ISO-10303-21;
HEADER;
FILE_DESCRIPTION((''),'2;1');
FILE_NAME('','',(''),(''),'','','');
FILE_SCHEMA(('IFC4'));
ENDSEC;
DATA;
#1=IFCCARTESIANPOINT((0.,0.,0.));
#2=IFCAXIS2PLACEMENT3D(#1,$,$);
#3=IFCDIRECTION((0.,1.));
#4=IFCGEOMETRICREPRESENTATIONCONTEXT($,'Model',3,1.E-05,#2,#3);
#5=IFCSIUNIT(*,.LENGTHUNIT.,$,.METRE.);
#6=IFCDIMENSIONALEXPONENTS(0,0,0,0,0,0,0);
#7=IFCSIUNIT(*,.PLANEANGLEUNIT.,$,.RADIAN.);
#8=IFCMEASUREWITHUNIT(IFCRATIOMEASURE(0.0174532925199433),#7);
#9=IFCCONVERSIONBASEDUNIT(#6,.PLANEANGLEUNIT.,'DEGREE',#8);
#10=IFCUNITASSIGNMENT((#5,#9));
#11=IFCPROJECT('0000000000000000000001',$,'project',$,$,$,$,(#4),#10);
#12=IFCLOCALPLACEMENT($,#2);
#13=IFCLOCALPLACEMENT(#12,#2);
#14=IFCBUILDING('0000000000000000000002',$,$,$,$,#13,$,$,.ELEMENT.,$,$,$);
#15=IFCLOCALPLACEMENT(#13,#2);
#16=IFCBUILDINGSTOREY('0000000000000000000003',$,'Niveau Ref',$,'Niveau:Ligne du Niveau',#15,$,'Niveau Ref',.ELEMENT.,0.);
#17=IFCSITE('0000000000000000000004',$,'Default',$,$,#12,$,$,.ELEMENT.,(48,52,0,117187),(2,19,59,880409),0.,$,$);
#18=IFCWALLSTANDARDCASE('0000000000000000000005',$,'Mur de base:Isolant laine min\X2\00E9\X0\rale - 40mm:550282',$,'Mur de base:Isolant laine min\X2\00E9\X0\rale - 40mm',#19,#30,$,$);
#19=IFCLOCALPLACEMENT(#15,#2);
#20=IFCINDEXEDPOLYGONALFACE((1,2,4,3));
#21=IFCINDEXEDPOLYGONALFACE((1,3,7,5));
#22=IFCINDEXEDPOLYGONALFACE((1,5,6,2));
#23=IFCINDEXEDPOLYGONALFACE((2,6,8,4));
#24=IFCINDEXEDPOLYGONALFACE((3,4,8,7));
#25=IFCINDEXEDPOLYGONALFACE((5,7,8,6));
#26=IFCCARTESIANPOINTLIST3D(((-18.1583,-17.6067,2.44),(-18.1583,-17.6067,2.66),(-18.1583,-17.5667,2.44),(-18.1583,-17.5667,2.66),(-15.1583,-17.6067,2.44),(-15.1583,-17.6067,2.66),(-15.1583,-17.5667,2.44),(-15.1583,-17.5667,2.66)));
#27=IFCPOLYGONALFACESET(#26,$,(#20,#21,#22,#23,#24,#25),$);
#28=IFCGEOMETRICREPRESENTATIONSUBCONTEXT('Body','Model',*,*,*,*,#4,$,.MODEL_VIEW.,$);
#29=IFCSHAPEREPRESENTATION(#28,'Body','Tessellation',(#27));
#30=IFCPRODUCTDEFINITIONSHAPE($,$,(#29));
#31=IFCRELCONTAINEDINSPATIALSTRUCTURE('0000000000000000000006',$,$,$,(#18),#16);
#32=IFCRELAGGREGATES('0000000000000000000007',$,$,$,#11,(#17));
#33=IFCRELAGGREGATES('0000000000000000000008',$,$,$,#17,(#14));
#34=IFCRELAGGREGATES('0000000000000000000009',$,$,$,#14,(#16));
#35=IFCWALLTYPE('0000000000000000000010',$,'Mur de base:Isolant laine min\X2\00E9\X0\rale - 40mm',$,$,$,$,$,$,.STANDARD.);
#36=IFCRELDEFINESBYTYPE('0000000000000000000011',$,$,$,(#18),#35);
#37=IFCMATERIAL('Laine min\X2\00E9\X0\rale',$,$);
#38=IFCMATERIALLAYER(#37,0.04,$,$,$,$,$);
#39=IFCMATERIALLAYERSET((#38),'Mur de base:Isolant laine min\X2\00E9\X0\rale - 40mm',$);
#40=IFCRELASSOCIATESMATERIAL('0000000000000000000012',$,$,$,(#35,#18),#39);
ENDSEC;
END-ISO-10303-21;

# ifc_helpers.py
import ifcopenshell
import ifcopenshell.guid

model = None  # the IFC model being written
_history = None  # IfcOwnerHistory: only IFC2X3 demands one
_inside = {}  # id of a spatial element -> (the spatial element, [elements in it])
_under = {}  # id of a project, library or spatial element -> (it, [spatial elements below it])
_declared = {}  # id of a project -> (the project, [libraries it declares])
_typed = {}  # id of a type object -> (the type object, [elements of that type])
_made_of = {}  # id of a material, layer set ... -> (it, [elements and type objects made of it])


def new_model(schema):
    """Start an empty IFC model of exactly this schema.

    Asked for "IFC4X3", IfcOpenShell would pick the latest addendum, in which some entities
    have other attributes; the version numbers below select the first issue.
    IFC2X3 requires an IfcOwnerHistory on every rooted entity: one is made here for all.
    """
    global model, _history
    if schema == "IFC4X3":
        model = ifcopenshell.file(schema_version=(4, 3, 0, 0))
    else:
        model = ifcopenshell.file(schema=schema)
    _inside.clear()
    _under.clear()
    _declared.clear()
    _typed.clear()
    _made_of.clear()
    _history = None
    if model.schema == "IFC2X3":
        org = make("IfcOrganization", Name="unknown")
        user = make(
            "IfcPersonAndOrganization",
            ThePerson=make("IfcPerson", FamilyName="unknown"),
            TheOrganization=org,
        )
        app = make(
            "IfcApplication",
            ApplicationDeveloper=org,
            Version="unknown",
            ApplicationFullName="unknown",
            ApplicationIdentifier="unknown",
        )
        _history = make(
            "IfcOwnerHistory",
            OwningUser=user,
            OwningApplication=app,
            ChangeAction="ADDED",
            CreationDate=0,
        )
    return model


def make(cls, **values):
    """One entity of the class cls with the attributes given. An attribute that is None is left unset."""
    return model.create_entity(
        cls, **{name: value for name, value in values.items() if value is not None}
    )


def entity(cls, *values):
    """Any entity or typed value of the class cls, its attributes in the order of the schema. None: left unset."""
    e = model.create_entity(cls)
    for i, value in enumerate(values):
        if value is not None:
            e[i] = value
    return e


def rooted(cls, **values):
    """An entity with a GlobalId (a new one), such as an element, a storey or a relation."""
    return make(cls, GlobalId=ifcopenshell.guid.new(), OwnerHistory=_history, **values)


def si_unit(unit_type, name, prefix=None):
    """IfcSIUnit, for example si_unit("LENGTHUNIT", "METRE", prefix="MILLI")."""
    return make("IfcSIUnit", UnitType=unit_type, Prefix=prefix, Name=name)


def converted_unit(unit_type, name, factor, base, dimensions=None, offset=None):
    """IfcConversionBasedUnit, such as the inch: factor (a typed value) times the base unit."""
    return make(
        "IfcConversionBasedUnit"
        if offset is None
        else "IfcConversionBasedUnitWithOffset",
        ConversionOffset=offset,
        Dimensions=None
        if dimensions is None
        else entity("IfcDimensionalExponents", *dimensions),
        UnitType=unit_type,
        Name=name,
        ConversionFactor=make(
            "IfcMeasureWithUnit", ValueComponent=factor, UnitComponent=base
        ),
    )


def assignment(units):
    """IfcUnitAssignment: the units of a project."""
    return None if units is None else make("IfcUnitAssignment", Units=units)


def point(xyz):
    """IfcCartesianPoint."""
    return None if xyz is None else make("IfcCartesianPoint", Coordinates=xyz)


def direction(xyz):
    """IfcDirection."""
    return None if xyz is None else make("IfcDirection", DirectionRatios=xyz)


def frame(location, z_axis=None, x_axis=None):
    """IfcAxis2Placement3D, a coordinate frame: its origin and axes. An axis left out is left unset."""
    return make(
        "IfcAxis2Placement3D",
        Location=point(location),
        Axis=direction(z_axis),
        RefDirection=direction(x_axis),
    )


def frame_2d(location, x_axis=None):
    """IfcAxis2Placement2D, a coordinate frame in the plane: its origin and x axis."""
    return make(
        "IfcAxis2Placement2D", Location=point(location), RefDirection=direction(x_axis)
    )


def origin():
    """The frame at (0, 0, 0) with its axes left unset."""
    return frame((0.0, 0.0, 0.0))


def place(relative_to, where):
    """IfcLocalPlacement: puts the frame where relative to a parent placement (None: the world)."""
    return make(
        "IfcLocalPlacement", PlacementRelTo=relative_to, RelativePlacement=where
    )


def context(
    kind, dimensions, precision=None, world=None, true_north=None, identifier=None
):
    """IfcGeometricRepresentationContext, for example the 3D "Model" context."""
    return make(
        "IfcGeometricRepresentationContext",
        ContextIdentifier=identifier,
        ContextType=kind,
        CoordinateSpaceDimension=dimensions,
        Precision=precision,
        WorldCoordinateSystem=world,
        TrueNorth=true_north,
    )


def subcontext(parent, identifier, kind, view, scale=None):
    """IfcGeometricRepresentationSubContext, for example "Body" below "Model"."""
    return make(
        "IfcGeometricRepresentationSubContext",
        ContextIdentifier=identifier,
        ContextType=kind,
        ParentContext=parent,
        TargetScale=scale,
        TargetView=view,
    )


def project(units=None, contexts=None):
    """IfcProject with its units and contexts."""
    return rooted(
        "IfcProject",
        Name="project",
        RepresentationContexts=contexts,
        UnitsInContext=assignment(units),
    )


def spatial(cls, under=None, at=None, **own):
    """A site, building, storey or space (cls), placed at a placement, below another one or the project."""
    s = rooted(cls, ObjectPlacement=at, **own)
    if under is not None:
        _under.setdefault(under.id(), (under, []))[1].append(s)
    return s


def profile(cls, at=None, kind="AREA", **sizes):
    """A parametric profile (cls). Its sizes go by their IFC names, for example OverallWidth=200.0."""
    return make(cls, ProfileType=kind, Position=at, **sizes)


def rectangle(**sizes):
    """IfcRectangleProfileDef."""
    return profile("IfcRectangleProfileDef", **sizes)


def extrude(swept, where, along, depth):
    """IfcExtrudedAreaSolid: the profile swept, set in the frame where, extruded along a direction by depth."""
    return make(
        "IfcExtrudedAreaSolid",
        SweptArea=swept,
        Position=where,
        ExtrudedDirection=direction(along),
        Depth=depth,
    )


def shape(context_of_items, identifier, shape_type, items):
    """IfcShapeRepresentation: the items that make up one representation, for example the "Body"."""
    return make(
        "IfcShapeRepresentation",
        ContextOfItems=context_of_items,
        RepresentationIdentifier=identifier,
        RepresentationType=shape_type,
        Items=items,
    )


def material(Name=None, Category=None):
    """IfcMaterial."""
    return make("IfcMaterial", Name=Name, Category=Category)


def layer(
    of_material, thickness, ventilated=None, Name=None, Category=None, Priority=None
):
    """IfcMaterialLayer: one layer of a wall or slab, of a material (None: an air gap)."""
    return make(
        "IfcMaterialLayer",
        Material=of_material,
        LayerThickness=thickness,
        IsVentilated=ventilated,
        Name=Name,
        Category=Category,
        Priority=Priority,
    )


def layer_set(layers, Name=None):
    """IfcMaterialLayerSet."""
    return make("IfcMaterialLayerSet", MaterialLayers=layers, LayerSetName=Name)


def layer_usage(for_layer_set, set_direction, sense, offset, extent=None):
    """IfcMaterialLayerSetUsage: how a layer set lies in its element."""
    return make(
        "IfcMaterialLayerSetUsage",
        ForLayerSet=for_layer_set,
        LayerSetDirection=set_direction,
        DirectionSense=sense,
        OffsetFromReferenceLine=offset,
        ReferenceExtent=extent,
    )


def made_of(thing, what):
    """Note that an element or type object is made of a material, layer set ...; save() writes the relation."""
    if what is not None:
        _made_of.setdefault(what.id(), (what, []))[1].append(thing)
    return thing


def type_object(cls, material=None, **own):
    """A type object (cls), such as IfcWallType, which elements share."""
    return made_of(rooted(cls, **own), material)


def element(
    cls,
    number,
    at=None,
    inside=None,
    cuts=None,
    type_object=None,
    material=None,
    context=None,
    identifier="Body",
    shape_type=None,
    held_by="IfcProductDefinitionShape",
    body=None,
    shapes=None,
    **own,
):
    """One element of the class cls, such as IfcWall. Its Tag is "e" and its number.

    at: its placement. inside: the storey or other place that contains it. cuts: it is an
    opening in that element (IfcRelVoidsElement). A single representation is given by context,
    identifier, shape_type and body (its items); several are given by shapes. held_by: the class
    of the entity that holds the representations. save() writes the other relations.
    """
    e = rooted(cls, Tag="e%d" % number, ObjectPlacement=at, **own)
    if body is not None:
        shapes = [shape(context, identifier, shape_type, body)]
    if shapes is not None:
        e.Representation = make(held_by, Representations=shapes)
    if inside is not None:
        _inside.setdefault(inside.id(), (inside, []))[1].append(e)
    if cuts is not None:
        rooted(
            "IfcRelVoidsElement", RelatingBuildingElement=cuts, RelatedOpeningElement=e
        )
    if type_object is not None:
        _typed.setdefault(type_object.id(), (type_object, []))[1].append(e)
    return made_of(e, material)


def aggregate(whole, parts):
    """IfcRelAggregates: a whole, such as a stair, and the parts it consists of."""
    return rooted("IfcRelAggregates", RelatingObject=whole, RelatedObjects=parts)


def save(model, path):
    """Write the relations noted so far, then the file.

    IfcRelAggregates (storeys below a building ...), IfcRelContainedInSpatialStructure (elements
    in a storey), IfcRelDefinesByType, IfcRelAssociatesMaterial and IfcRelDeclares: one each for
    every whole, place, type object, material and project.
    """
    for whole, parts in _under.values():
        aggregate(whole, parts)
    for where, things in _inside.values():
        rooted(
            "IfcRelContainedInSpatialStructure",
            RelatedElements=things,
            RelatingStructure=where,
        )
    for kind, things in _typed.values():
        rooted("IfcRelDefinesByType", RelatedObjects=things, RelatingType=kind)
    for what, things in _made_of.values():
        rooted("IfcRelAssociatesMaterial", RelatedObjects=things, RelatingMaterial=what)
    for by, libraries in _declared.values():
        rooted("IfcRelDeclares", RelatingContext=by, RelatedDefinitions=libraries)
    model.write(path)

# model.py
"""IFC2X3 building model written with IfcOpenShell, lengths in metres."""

from ifc_helpers import new_model, entity, si_unit, converted_unit, direction, frame, frame_2d, origin, place, context, subcontext, project, spatial, rectangle, extrude, material, layer, layer_set, layer_usage, type_object, element, save


model = new_model("IFC2X3")

# Units and contexts
model_context = context("Model", 3, precision=1e-05, world=origin(), true_north=direction((0.0, 1.0)))
body_context = subcontext(model_context, "Body", "Model", "MODEL_VIEW")
ifc_project = project(units=[si_unit("LENGTHUNIT", "METRE"), converted_unit("PLANEANGLEUNIT", "DEGREE", entity("IfcRatioMeasure", 0.0174532925199433), si_unit("PLANEANGLEUNIT", "RADIAN"), dimensions=[0, 0, 0, 0, 0, 0, 0])], contexts=[model_context])

# Site, building, storey
site_placement = place(None, origin())
site = spatial("IfcSite", under=ifc_project, at=site_placement, Name="Default", CompositionType="ELEMENT", RefLatitude=(48, 52, 0, 117187), RefLongitude=(2, 19, 59, 880409), RefElevation=0.0)
building_placement = place(site_placement, origin())
building = spatial("IfcBuilding", under=site, at=building_placement, CompositionType="ELEMENT")
storey_placement = place(building_placement, origin())
storey = spatial("IfcBuildingStorey", under=building, at=storey_placement, Name="Niveau Ref", ObjectType="Niveau:Ligne du Niveau", LongName="Niveau Ref", CompositionType="ELEMENT", Elevation=0.0)

# Wall
ifc_material_1 = material(Name="Laine minérale")
ifc_layer = layer(ifc_material_1, 0.04)
ifc_layer_set = layer_set([ifc_layer], Name="Mur de base:Isolant laine minérale - 40mm")
wall_type = type_object("IfcWallType", Name="Mur de base:Isolant laine minérale - 40mm", PredefinedType="STANDARD", material=ifc_layer_set)
ifc_layer_usage_1 = layer_usage(ifc_layer_set, "AXIS2", "NEGATIVE", 0.02)
wall_1_placement = place(storey_placement, frame((-18.1583, -17.5867, 2.44)))
element("IfcWallStandardCase", 1, at=wall_1_placement, inside=storey, type_object=wall_type, material=ifc_layer_usage_1, Name="Mur de base:Isolant laine minérale - 40mm:550282", ObjectType="Mur de base:Isolant laine minérale - 40mm", context=body_context, shape_type="SweptSolid", body=[
    extrude(rectangle(XDim=3.0, YDim=0.04, at=frame_2d((1.5, 0.0), x_axis=(-1.0, 0.0))), origin(), (0.0, 0.0, 1.0), 0.22),
])

save(model, "model.ifc")
